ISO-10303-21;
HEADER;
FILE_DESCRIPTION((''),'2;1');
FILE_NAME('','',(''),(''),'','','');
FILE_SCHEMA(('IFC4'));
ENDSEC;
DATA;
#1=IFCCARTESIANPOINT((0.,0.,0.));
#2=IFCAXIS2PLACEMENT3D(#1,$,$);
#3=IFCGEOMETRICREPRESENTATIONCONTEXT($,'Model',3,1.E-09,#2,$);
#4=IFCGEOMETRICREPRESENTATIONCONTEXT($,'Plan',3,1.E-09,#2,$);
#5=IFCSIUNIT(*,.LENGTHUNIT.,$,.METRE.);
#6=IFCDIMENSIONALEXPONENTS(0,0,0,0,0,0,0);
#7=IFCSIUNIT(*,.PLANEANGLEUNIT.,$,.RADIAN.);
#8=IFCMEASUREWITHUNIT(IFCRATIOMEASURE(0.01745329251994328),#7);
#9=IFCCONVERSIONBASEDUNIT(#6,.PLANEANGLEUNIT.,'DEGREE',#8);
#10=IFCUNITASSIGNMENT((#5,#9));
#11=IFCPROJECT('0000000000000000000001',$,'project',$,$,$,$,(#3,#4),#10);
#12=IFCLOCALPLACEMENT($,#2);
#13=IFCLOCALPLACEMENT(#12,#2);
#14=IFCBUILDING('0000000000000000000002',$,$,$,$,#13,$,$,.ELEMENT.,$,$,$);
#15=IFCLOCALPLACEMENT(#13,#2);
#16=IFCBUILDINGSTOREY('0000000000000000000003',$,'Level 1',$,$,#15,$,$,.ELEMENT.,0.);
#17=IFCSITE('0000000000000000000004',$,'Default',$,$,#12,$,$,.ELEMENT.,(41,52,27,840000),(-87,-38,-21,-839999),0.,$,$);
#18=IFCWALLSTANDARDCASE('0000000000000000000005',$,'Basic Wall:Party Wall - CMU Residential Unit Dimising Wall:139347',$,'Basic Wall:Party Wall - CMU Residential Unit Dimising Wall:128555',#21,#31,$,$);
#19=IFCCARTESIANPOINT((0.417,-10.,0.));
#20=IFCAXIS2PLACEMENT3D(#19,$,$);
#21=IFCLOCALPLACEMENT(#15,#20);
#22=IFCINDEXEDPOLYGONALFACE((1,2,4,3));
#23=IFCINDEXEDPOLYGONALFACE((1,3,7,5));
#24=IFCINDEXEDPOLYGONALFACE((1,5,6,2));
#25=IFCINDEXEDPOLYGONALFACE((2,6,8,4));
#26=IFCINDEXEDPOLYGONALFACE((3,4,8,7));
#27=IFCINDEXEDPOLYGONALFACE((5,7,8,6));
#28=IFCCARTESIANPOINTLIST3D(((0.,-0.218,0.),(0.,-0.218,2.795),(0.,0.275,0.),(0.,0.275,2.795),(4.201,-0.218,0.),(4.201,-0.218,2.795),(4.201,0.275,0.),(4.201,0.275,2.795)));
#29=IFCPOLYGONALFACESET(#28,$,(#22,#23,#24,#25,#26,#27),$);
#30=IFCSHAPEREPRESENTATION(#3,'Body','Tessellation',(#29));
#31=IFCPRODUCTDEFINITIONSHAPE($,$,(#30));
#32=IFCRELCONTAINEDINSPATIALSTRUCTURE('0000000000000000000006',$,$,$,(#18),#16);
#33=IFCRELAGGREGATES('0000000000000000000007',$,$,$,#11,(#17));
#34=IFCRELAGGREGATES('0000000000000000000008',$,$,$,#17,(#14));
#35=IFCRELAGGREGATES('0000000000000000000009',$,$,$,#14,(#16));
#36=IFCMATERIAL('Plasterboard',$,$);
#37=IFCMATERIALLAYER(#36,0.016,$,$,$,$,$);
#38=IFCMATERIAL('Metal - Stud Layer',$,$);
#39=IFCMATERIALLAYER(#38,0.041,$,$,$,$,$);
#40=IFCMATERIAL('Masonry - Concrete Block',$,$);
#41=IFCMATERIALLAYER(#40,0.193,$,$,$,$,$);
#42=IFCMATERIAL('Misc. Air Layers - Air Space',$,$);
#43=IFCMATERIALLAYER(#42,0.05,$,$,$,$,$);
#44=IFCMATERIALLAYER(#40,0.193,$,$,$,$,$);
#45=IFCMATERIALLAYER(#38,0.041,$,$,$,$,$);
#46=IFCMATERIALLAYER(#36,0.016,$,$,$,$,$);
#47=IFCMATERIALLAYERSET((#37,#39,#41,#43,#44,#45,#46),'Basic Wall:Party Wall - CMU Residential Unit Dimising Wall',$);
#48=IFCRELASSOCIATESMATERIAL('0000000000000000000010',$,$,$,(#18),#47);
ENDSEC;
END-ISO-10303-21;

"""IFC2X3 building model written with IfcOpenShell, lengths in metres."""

from ifc_helpers import new_model, entity, si_unit, converted_unit, frame, frame_2d, origin, place, context, project, spatial, polyline, rectangle, extrude, clip, bounded_halfspace, material, layer, layer_set, layer_usage, element, save


model = new_model("IFC2X3")

# Units and contexts
model_context = context("Model", 3, precision=1e-09, world=origin())
plan_context = context("Plan", 3, precision=1e-09, world=origin())
ifc_project = project(units=[si_unit("LENGTHUNIT", "METRE"), converted_unit("PLANEANGLEUNIT", "DEGREE", entity("IfcRatioMeasure", 0.01745329251994328), si_unit("PLANEANGLEUNIT", "RADIAN"), dimensions=[0, 0, 0, 0, 0, 0, 0])], contexts=[model_context, plan_context])

# Site, building, storey
site_placement = place(None, origin())
site = spatial("IfcSite", under=ifc_project, at=site_placement, Name="Default", CompositionType="ELEMENT", RefLatitude=(41, 52, 27, 840000), RefLongitude=(-87, -38, -21, -839999), RefElevation=0.0)
building_placement = place(site_placement, origin())
building = spatial("IfcBuilding", under=site, at=building_placement, CompositionType="ELEMENT")
storey_placement = place(building_placement, origin())
storey = spatial("IfcBuildingStorey", under=building, at=storey_placement, Name="Level 1", CompositionType="ELEMENT", Elevation=0.0)

# Wall
ifc_material_1 = material(Name="Plasterboard")
ifc_layer_1 = layer(ifc_material_1, 0.016)
ifc_material_2 = material(Name="Metal - Stud Layer")
ifc_layer_2 = layer(ifc_material_2, 0.041)
ifc_material_3 = material(Name="Masonry - Concrete Block")
ifc_layer_3 = layer(ifc_material_3, 0.193)
ifc_material_4 = material(Name="Misc. Air Layers - Air Space")
ifc_layer_4 = layer(ifc_material_4, 0.05)
ifc_layer_5 = layer(ifc_material_3, 0.193)
ifc_layer_6 = layer(ifc_material_2, 0.041)
ifc_layer_7 = layer(ifc_material_1, 0.016)
ifc_layer_set_1 = layer_set([ifc_layer_1, ifc_layer_2, ifc_layer_3, ifc_layer_4, ifc_layer_5, ifc_layer_6, ifc_layer_7], Name="Basic Wall:Party Wall - CMU Residential Unit Dimising Wall")
ifc_layer_usage_1 = layer_usage(ifc_layer_set_1, "AXIS2", "NEGATIVE", 0.275)
wall_1_placement = place(storey_placement, frame((0.417, -10.0, 0.0)))
element("IfcWallStandardCase", 1, at=wall_1_placement, inside=storey, material=ifc_layer_usage_1, Name="Basic Wall:Party Wall - CMU Residential Unit Dimising Wall:139347", ObjectType="Basic Wall:Party Wall - CMU Residential Unit Dimising Wall:128555", context=model_context, shape_type="Clipping", body=[
    clip(clip(extrude(rectangle(XDim=4.201, YDim=0.55, at=frame_2d((2.1005, 0.0), x_axis=(-1.0, 0.0))), origin(), (0.0, 0.0, 1.0), 2.795), bounded_halfspace(frame((0.0, -0.218, 0.0), z_axis=(0.0, 1.0, 0.0), x_axis=(-1.0, 0.0, 0.0)), True, frame((0.0, -0.218, 0.0), z_axis=(0.0, 1.0, 0.0), x_axis=(-1.0, 0.0, 0.0)), polyline([(0.0, 0.0), (0.0, 2.795), (-4.201, 2.795), (-4.201, 0.0), (0.0, 0.0)]))), bounded_halfspace(frame((4.201, 0.275, 0.0), z_axis=(-1.0, 0.0, 0.0), x_axis=(0.0, -1.0, 0.0)), True, frame((4.201, 0.275, 0.0), z_axis=(-1.0, 0.0, 0.0), x_axis=(0.0, -1.0, 0.0)), polyline([(0.0, 0.0), (0.493, 0.0), (0.493, 2.795), (0.0, 2.795), (0.0, 0.0)]))),
])

save(model, "model.ifc")
